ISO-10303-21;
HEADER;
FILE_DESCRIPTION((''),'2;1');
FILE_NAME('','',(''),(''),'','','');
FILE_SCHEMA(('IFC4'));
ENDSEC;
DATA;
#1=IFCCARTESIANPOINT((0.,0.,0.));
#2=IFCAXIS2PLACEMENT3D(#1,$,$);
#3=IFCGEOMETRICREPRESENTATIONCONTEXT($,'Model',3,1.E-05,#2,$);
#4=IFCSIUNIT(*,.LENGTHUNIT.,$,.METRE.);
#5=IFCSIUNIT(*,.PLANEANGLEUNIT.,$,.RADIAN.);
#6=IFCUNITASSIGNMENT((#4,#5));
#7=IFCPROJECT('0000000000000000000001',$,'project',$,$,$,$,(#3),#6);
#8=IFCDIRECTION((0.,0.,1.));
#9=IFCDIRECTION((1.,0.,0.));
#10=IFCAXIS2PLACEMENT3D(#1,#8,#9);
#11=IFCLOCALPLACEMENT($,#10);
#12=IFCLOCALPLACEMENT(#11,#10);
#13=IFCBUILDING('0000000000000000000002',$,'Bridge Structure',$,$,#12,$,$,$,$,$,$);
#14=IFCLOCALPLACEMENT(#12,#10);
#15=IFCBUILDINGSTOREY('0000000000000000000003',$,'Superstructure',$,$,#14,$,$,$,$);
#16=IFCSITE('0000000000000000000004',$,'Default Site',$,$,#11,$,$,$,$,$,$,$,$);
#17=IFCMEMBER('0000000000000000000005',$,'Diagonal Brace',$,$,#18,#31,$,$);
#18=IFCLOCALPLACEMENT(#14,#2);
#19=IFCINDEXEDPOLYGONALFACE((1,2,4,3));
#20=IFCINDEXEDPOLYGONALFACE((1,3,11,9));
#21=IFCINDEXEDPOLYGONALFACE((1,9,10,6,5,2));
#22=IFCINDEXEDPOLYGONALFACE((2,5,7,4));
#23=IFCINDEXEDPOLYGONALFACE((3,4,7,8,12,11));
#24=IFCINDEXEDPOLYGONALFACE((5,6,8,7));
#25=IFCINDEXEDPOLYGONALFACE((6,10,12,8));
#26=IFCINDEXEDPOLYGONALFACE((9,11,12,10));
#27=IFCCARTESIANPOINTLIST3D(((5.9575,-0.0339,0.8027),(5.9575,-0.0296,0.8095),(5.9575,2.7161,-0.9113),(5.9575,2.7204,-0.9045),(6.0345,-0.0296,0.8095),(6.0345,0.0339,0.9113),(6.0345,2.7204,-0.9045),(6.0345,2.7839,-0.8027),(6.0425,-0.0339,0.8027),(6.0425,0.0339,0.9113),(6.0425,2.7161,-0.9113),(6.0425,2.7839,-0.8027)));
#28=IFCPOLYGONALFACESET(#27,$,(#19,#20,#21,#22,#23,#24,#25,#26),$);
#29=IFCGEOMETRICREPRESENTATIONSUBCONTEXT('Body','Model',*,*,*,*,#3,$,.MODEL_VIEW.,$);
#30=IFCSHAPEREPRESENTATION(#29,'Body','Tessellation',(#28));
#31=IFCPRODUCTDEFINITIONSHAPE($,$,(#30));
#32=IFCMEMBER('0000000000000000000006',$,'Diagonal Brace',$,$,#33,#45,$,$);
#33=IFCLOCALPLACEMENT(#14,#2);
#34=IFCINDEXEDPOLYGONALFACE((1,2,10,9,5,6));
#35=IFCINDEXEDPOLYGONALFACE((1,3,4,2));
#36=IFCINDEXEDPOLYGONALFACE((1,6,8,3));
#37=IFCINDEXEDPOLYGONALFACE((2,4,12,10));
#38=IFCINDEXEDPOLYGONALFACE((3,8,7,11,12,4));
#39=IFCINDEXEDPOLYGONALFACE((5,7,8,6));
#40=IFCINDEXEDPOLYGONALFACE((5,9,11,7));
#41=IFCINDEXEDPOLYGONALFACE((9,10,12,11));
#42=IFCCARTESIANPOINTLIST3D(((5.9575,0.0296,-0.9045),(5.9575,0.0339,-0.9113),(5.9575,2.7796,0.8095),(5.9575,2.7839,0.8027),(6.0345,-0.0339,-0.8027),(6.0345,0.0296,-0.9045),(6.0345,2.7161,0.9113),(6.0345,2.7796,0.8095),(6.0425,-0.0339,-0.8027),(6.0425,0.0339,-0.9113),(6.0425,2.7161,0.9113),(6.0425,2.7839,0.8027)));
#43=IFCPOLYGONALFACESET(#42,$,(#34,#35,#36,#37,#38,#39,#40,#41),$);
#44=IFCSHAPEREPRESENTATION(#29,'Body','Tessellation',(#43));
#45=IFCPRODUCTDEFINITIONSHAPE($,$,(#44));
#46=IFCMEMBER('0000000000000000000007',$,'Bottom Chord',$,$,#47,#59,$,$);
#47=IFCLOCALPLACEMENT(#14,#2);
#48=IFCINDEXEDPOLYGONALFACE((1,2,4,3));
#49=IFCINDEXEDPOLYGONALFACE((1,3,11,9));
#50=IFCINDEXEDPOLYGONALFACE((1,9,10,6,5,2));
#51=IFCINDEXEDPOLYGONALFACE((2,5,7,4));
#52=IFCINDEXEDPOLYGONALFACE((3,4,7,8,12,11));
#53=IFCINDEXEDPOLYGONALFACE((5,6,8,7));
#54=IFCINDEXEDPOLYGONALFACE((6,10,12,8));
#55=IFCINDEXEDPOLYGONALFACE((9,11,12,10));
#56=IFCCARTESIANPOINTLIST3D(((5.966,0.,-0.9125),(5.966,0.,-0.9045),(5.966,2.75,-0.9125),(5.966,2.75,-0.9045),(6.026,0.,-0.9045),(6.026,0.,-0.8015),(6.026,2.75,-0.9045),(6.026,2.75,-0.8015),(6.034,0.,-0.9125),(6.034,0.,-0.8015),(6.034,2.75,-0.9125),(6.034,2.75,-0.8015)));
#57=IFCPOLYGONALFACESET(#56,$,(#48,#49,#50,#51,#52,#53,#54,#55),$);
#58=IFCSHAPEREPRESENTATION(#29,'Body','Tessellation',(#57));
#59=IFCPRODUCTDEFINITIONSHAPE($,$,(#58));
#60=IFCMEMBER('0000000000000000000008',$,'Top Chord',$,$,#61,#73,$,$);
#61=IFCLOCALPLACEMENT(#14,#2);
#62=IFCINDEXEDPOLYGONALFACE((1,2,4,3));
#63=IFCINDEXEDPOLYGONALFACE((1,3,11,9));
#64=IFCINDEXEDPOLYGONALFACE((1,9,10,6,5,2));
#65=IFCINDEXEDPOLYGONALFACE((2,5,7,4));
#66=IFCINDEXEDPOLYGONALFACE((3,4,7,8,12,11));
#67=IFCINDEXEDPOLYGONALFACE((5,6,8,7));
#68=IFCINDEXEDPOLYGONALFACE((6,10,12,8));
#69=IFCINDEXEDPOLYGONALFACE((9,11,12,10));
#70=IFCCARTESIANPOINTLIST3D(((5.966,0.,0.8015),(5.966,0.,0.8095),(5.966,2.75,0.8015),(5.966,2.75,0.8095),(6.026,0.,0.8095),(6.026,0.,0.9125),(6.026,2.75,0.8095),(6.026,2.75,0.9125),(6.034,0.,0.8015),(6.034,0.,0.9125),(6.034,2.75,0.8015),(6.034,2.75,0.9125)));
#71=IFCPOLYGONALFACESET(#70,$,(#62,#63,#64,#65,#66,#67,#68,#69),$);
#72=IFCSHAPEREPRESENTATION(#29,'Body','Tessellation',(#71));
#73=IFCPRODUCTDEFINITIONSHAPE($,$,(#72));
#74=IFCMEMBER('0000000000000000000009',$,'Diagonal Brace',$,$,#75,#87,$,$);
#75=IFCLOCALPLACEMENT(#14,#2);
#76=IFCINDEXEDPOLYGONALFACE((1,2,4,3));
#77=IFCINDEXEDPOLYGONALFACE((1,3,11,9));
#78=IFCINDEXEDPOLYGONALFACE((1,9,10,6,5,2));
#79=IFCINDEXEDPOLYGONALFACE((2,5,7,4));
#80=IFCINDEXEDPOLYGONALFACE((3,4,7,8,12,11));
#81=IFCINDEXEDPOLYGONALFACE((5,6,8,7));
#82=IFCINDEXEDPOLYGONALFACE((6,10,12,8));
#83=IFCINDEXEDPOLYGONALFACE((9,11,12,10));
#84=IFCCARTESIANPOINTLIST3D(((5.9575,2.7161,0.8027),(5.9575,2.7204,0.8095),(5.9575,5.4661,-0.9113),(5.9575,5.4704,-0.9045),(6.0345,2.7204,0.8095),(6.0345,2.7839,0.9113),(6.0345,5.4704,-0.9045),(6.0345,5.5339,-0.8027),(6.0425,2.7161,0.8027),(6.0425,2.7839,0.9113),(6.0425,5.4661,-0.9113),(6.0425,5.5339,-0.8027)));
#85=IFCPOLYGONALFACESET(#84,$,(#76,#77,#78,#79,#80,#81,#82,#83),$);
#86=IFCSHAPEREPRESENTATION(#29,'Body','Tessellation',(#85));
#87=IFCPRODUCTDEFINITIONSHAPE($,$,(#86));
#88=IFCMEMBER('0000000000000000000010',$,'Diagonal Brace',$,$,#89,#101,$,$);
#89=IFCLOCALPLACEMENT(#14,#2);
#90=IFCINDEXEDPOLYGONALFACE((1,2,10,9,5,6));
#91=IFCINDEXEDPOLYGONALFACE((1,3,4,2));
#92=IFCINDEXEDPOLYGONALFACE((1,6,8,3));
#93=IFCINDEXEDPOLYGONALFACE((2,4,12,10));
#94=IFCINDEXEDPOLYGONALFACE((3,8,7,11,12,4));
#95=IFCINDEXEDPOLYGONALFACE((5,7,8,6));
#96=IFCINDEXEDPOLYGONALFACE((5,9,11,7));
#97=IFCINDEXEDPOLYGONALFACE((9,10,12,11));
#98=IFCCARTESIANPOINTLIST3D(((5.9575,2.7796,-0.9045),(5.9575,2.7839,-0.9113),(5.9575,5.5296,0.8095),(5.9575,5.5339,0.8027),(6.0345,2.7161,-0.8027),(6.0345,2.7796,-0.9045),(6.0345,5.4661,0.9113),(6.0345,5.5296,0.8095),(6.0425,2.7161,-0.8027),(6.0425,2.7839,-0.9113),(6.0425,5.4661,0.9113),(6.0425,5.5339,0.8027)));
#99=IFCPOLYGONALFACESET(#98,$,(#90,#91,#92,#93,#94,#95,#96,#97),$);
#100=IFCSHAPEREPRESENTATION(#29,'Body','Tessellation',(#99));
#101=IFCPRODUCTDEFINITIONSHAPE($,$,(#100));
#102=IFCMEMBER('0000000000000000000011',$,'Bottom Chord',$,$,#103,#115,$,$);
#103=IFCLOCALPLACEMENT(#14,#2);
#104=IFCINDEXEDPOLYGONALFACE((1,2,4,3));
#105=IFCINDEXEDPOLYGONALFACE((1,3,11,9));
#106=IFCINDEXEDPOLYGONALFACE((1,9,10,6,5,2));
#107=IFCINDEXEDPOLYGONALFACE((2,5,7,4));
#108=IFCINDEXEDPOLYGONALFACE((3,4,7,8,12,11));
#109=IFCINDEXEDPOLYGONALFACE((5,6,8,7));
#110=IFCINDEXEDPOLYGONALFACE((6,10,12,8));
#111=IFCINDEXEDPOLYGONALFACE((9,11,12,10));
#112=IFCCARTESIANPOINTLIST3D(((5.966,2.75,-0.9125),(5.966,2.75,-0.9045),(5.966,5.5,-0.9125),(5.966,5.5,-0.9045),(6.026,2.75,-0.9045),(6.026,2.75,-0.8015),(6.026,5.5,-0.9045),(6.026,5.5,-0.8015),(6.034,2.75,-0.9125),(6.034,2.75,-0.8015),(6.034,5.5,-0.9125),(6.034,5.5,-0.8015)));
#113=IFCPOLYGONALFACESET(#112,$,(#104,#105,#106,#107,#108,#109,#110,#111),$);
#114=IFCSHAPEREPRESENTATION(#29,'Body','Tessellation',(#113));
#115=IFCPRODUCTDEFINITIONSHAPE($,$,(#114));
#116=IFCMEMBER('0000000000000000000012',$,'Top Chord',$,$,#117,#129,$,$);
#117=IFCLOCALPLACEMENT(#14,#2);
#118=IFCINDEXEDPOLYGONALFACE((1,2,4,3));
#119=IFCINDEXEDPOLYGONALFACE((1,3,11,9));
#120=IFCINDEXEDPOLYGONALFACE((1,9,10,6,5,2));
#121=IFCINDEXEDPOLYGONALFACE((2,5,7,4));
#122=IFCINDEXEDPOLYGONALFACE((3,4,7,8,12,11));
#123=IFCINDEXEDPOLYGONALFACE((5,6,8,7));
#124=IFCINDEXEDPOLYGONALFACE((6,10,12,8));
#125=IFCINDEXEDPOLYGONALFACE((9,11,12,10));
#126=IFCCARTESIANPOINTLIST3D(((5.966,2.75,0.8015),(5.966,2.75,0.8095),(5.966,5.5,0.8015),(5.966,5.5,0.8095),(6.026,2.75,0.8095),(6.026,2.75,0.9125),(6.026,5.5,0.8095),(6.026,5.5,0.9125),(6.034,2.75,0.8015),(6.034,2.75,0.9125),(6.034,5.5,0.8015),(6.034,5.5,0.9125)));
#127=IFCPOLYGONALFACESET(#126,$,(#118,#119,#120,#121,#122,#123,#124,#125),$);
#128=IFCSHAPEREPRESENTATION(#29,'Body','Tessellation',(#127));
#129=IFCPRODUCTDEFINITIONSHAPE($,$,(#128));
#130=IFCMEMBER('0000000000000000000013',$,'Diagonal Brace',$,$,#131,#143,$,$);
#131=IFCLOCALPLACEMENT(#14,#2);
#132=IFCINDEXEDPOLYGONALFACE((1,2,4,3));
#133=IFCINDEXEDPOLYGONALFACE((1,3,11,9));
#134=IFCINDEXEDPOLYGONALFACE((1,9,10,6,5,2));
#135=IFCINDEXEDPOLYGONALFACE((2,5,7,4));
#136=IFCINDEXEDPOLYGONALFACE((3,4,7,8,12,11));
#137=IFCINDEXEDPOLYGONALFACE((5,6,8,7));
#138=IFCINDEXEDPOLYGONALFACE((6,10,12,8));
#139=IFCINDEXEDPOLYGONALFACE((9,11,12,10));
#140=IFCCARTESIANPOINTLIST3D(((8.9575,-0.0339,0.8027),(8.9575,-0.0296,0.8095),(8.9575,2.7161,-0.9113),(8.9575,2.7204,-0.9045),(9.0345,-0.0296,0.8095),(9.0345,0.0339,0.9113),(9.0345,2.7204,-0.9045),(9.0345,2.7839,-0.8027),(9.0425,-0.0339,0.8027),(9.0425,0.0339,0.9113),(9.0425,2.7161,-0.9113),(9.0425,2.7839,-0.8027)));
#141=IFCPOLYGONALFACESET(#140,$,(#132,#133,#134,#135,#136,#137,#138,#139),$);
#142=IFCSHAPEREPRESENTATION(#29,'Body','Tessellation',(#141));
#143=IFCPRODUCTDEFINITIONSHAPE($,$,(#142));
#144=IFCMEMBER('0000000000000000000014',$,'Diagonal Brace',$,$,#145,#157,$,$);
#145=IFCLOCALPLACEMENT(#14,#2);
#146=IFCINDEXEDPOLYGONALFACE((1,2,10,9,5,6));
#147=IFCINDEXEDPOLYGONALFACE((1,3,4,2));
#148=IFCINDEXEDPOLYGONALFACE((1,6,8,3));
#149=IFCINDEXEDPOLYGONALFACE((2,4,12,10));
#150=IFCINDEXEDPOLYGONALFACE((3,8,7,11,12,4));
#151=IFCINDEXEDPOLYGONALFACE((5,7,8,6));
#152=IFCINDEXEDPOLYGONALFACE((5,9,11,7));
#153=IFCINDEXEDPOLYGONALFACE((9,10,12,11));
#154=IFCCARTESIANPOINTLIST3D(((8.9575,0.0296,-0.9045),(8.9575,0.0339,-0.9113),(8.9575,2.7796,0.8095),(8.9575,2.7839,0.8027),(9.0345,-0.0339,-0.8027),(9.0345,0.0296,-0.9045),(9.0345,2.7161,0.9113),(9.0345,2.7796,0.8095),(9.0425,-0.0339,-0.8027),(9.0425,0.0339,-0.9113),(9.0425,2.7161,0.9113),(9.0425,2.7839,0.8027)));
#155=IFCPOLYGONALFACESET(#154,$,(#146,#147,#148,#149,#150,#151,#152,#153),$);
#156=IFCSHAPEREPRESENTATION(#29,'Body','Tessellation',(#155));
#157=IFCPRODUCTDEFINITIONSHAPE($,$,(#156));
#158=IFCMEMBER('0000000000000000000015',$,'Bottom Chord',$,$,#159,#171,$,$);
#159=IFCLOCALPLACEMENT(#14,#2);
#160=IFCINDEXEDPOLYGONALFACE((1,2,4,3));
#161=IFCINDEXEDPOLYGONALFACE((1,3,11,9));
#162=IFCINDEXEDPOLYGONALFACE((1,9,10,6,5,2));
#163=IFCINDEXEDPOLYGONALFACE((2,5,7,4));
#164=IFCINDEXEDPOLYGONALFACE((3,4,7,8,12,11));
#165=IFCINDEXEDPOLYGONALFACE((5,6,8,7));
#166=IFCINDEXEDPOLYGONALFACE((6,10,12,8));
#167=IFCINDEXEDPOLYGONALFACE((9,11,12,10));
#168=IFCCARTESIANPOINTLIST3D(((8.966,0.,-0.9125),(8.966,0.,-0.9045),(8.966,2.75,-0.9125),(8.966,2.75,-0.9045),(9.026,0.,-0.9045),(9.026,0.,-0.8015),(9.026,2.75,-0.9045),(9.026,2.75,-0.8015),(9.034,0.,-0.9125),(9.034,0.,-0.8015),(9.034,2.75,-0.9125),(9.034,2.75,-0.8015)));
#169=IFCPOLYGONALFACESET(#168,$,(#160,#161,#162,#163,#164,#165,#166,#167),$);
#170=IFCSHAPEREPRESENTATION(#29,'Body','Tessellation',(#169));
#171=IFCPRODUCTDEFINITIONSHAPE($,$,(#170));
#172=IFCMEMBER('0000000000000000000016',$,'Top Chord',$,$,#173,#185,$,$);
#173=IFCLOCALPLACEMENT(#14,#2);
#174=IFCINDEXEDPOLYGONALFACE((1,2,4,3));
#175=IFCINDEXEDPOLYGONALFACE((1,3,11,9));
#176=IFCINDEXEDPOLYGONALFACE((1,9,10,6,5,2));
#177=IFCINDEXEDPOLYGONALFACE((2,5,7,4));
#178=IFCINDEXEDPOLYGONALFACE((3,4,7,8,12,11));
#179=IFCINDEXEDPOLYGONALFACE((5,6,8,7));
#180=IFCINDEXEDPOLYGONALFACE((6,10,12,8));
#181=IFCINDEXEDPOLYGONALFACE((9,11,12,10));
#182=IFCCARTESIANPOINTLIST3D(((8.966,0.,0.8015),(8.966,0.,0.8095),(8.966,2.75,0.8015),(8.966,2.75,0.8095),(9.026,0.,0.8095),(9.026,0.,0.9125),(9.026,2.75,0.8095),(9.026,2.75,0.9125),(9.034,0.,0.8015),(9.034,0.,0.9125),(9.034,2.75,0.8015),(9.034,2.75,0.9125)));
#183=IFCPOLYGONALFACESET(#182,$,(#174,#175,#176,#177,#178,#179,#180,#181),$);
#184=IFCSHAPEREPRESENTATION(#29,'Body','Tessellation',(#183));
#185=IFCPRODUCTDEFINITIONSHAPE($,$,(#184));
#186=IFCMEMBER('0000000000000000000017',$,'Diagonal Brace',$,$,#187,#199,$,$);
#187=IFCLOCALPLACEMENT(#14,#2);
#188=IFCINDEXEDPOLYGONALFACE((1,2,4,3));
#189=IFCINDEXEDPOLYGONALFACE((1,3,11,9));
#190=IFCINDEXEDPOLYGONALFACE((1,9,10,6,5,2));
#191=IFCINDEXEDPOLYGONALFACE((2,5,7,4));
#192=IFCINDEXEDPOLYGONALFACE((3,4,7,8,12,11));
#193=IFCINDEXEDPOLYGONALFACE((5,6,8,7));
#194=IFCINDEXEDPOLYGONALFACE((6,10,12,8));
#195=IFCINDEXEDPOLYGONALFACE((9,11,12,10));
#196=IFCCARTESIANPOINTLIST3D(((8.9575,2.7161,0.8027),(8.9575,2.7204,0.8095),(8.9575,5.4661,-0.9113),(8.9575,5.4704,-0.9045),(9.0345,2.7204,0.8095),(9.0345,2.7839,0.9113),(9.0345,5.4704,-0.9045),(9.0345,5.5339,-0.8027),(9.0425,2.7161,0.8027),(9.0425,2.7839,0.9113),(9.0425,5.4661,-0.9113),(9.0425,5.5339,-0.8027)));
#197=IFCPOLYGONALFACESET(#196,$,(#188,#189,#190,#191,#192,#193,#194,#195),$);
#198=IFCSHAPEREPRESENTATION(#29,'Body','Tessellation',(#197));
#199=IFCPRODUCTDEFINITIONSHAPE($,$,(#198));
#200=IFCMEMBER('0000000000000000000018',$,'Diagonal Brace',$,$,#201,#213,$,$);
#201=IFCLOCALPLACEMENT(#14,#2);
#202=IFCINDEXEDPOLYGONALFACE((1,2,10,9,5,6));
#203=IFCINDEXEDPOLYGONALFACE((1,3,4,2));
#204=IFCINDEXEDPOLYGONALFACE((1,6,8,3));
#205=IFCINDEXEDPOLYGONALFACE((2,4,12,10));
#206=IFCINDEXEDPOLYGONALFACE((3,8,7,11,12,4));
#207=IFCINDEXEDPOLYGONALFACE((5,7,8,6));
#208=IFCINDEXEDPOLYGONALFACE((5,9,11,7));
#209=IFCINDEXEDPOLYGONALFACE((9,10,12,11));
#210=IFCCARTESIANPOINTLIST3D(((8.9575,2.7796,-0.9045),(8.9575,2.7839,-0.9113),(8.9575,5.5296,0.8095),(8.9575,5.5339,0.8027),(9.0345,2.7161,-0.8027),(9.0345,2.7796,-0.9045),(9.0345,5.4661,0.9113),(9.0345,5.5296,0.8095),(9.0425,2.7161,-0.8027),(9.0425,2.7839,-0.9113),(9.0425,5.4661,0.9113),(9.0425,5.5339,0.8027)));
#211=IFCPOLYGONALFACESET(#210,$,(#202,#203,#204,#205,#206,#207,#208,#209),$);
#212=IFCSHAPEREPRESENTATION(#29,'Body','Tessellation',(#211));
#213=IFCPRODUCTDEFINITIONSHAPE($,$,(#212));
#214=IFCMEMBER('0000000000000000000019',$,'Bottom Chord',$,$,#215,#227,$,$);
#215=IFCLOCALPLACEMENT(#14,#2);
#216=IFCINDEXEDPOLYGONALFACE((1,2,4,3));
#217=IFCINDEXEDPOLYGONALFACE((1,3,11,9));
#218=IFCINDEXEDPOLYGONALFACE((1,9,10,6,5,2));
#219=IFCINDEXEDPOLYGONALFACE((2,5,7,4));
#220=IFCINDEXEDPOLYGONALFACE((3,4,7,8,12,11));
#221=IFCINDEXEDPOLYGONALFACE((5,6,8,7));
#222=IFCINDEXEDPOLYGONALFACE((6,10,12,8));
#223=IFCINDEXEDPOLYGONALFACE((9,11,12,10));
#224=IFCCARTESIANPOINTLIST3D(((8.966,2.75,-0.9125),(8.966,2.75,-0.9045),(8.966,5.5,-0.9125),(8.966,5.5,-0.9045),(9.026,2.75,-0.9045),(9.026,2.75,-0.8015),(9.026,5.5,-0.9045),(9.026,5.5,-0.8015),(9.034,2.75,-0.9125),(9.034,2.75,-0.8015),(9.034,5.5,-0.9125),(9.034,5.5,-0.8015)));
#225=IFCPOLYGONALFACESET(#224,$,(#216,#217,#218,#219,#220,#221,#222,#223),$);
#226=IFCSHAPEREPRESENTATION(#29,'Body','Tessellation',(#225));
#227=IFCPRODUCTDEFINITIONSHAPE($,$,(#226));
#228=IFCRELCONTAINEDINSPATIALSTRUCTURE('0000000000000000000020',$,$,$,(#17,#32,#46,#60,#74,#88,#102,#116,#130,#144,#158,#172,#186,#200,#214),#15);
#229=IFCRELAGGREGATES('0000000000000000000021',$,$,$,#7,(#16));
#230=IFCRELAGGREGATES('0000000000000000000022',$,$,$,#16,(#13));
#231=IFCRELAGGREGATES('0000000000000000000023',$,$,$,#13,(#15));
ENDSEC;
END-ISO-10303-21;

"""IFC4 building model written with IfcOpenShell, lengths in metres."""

from ifc_helpers import new_model, si_unit, frame, origin, origin_with_axes, origin_2d_with_axis, place, context, subcontext, project, spatial, l_section, extrude, element, save


model = new_model("IFC4")

# Units and contexts
model_context = context("Model", 3, precision=1e-05, world=origin())
body_context = subcontext(model_context, "Body", "Model", "MODEL_VIEW")
ifc_project = project(units=[si_unit("LENGTHUNIT", "METRE"), si_unit("PLANEANGLEUNIT", "RADIAN")], contexts=[model_context])

# Site, building, storey
site_placement = place(None, origin_with_axes())
site = spatial("IfcSite", under=ifc_project, at=site_placement, Name="Default Site")
building_placement = place(site_placement, origin_with_axes())
building = spatial("IfcBuilding", under=site, at=building_placement, Name="Bridge Structure")
storey_placement = place(building_placement, origin_with_axes())
storey = spatial("IfcBuildingStorey", under=building, at=storey_placement, Name="Superstructure")

# Members
for number, where, z_axis, x_axis, name in (
    (1, (6.0, 0.0, 0.857), (0.0, 0.848656, -0.528944), (-1.0, 0.0, 0.0), "Diagonal Brace"),
    (2, (6.0, 0.0, -0.857), (0.0, 0.848656, 0.528944), (-1.0, 0.0, 0.0), "Diagonal Brace"),
):
    element("IfcMember", number, at=place(storey_placement, frame(where, z_axis=z_axis, x_axis=x_axis)), inside=storey, Name=name, context=body_context, shape_type="SweptSolid", body=[
        extrude(l_section(Depth=0.128, Width=0.085, Thickness=0.008, at=origin_2d_with_axis()), origin_with_axes(), (0.0, 0.0, 1.0), 3.2404),
    ])
for number, where, z_axis, x_axis, name in (
    (3, (6.0, 0.0, -0.857), (0.0, 1.0, 0.0), (-1.0, 0.0, 0.0), "Bottom Chord"),
    (4, (6.0, 0.0, 0.857), (0.0, 1.0, 0.0), (-1.0, 0.0, 0.0), "Top Chord"),
):
    element("IfcMember", number, at=place(storey_placement, frame(where, z_axis=z_axis, x_axis=x_axis)), inside=storey, Name=name, context=body_context, shape_type="SweptSolid", body=[
        extrude(l_section(Depth=0.111, Width=0.068, Thickness=0.008, at=origin_2d_with_axis()), origin_with_axes(), (0.0, 0.0, 1.0), 2.75),
    ])
for number, where, z_axis, x_axis, name in (
    (5, (6.0, 2.75, 0.857), (0.0, 0.848656, -0.528944), (-1.0, 0.0, 0.0), "Diagonal Brace"),
    (6, (6.0, 2.75, -0.857), (0.0, 0.848656, 0.528944), (-1.0, 0.0, 0.0), "Diagonal Brace"),
):
    element("IfcMember", number, at=place(storey_placement, frame(where, z_axis=z_axis, x_axis=x_axis)), inside=storey, Name=name, context=body_context, shape_type="SweptSolid", body=[
        extrude(l_section(Depth=0.128, Width=0.085, Thickness=0.008, at=origin_2d_with_axis()), origin_with_axes(), (0.0, 0.0, 1.0), 3.2404),
    ])
for number, where, z_axis, x_axis, name in (
    (7, (6.0, 2.75, -0.857), (0.0, 1.0, 0.0), (-1.0, 0.0, 0.0), "Bottom Chord"),
    (8, (6.0, 2.75, 0.857), (0.0, 1.0, 0.0), (-1.0, 0.0, 0.0), "Top Chord"),
):
    element("IfcMember", number, at=place(storey_placement, frame(where, z_axis=z_axis, x_axis=x_axis)), inside=storey, Name=name, context=body_context, shape_type="SweptSolid", body=[
        extrude(l_section(Depth=0.111, Width=0.068, Thickness=0.008, at=origin_2d_with_axis()), origin_with_axes(), (0.0, 0.0, 1.0), 2.75),
    ])
for number, where, z_axis, x_axis, name in (
    (9, (9.0, 0.0, 0.857), (0.0, 0.848656, -0.528944), (-1.0, 0.0, 0.0), "Diagonal Brace"),
    (10, (9.0, 0.0, -0.857), (0.0, 0.848656, 0.528944), (-1.0, 0.0, 0.0), "Diagonal Brace"),
):
    element("IfcMember", number, at=place(storey_placement, frame(where, z_axis=z_axis, x_axis=x_axis)), inside=storey, Name=name, context=body_context, shape_type="SweptSolid", body=[
        extrude(l_section(Depth=0.128, Width=0.085, Thickness=0.008, at=origin_2d_with_axis()), origin_with_axes(), (0.0, 0.0, 1.0), 3.2404),
    ])
for number, where, z_axis, x_axis, name in (
    (11, (9.0, 0.0, -0.857), (0.0, 1.0, 0.0), (-1.0, 0.0, 0.0), "Bottom Chord"),
    (12, (9.0, 0.0, 0.857), (0.0, 1.0, 0.0), (-1.0, 0.0, 0.0), "Top Chord"),
):
    element("IfcMember", number, at=place(storey_placement, frame(where, z_axis=z_axis, x_axis=x_axis)), inside=storey, Name=name, context=body_context, shape_type="SweptSolid", body=[
        extrude(l_section(Depth=0.111, Width=0.068, Thickness=0.008, at=origin_2d_with_axis()), origin_with_axes(), (0.0, 0.0, 1.0), 2.75),
    ])
for number, where, z_axis, x_axis, name in (
    (13, (9.0, 2.75, 0.857), (0.0, 0.848656, -0.528944), (-1.0, 0.0, 0.0), "Diagonal Brace"),
    (14, (9.0, 2.75, -0.857), (0.0, 0.848656, 0.528944), (-1.0, 0.0, 0.0), "Diagonal Brace"),
):
    element("IfcMember", number, at=place(storey_placement, frame(where, z_axis=z_axis, x_axis=x_axis)), inside=storey, Name=name, context=body_context, shape_type="SweptSolid", body=[
        extrude(l_section(Depth=0.128, Width=0.085, Thickness=0.008, at=origin_2d_with_axis()), origin_with_axes(), (0.0, 0.0, 1.0), 3.2404),
    ])
for number, where, z_axis, x_axis, name in (
    (15, (9.0, 2.75, -0.857), (0.0, 1.0, 0.0), (-1.0, 0.0, 0.0), "Bottom Chord"),
):
    element("IfcMember", number, at=place(storey_placement, frame(where, z_axis=z_axis, x_axis=x_axis)), inside=storey, Name=name, context=body_context, shape_type="SweptSolid", body=[
        extrude(l_section(Depth=0.111, Width=0.068, Thickness=0.008, at=origin_2d_with_axis()), origin_with_axes(), (0.0, 0.0, 1.0), 2.75),
    ])

save(model, "model.ifc")
